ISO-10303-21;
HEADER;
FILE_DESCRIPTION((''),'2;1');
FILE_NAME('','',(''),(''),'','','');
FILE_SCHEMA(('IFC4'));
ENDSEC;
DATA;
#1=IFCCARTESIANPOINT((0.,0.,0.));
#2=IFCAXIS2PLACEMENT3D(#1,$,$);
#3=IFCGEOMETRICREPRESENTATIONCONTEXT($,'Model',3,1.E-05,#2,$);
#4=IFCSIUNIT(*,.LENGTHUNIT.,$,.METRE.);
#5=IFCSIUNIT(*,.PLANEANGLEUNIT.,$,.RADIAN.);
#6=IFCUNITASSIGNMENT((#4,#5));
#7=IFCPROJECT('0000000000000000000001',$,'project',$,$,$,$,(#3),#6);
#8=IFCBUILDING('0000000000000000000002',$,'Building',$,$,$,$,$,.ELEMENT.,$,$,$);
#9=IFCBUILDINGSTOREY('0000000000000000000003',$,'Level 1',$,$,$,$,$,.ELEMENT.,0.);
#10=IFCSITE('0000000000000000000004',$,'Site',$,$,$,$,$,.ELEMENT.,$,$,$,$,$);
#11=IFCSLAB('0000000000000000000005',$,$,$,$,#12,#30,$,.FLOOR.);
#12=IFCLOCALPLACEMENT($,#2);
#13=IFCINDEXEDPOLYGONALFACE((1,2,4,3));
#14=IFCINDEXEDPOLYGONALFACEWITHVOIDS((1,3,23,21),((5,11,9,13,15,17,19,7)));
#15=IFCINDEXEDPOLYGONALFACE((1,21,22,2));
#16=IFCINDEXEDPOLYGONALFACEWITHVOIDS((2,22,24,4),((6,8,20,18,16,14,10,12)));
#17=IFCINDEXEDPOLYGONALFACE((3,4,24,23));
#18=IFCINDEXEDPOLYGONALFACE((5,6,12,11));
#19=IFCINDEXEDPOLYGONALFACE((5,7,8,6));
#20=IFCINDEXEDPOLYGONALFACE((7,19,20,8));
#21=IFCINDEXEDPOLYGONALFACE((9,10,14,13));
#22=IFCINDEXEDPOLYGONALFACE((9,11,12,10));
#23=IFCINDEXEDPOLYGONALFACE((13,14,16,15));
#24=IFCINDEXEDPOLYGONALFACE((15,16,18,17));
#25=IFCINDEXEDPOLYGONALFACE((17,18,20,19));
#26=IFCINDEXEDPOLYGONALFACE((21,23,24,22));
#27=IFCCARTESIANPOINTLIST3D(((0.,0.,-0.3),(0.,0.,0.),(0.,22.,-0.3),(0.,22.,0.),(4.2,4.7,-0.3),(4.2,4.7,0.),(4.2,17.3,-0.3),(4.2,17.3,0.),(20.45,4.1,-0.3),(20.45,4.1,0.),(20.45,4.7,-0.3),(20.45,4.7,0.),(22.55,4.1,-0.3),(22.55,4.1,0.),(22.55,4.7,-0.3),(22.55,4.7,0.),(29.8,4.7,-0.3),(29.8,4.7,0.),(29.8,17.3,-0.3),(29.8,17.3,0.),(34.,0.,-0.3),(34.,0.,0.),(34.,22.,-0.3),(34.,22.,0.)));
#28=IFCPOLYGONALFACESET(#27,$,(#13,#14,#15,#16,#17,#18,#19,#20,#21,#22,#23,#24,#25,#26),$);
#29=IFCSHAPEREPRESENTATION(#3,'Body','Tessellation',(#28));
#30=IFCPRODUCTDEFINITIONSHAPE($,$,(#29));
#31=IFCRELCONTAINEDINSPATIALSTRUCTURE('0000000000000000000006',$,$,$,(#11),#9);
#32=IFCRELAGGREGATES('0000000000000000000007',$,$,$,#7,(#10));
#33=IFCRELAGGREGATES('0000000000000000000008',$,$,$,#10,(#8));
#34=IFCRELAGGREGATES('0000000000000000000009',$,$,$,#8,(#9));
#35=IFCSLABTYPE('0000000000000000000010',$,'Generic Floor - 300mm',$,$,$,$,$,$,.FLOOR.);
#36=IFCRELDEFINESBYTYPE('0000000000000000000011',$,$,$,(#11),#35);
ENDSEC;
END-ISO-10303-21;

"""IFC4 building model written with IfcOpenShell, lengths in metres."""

from ifc_helpers import new_model, si_unit, frame, origin, place, context, project, spatial, polyline, outline, extrude, type_object, element, save


model = new_model("IFC4")

# Units and contexts
model_context = context("Model", 3, precision=1e-05, world=origin())
ifc_project = project(units=[si_unit("LENGTHUNIT", "METRE"), si_unit("PLANEANGLEUNIT", "RADIAN")], contexts=[model_context])

# Site, building, storey
site = spatial("IfcSite", under=ifc_project, Name="Site", CompositionType="ELEMENT")
building = spatial("IfcBuilding", under=site, Name="Building", CompositionType="ELEMENT")
storey = spatial("IfcBuildingStorey", under=building, Name="Level 1", CompositionType="ELEMENT", Elevation=0.0)

# Slab, opening
slab_type = type_object("IfcSlabType", Name="Generic Floor - 300mm", PredefinedType="FLOOR")
slab_placement = place(None, origin())
slab = element("IfcSlab", 1, at=slab_placement, inside=storey, type_object=slab_type, PredefinedType="FLOOR", context=model_context, shape_type="SweptSolid", body=[
    extrude(outline(polyline([(0.0, 0.0), (34.0, 0.0), (34.0, 22.0), (0.0, 22.0), (0.0, 0.0)])), origin(), (0.0, 0.0, -1.0), 0.3),
])
opening_placement = place(None, frame((0.0, 0.0, 0.001)))
element("IfcOpeningElement", 2, at=opening_placement, cuts=slab, PredefinedType="OPENING", context=model_context, shape_type="SweptSolid", body=[
    extrude(outline(polyline([(4.2, 17.3), (4.2, 4.7), (20.45, 4.7), (20.45, 4.1), (22.55, 4.1), (22.55, 4.7), (29.8, 4.7), (29.8, 17.3), (4.2, 17.3)])), origin(), (0.0, 0.0, -1.0), 0.302),
])

save(model, "model.ifc")
